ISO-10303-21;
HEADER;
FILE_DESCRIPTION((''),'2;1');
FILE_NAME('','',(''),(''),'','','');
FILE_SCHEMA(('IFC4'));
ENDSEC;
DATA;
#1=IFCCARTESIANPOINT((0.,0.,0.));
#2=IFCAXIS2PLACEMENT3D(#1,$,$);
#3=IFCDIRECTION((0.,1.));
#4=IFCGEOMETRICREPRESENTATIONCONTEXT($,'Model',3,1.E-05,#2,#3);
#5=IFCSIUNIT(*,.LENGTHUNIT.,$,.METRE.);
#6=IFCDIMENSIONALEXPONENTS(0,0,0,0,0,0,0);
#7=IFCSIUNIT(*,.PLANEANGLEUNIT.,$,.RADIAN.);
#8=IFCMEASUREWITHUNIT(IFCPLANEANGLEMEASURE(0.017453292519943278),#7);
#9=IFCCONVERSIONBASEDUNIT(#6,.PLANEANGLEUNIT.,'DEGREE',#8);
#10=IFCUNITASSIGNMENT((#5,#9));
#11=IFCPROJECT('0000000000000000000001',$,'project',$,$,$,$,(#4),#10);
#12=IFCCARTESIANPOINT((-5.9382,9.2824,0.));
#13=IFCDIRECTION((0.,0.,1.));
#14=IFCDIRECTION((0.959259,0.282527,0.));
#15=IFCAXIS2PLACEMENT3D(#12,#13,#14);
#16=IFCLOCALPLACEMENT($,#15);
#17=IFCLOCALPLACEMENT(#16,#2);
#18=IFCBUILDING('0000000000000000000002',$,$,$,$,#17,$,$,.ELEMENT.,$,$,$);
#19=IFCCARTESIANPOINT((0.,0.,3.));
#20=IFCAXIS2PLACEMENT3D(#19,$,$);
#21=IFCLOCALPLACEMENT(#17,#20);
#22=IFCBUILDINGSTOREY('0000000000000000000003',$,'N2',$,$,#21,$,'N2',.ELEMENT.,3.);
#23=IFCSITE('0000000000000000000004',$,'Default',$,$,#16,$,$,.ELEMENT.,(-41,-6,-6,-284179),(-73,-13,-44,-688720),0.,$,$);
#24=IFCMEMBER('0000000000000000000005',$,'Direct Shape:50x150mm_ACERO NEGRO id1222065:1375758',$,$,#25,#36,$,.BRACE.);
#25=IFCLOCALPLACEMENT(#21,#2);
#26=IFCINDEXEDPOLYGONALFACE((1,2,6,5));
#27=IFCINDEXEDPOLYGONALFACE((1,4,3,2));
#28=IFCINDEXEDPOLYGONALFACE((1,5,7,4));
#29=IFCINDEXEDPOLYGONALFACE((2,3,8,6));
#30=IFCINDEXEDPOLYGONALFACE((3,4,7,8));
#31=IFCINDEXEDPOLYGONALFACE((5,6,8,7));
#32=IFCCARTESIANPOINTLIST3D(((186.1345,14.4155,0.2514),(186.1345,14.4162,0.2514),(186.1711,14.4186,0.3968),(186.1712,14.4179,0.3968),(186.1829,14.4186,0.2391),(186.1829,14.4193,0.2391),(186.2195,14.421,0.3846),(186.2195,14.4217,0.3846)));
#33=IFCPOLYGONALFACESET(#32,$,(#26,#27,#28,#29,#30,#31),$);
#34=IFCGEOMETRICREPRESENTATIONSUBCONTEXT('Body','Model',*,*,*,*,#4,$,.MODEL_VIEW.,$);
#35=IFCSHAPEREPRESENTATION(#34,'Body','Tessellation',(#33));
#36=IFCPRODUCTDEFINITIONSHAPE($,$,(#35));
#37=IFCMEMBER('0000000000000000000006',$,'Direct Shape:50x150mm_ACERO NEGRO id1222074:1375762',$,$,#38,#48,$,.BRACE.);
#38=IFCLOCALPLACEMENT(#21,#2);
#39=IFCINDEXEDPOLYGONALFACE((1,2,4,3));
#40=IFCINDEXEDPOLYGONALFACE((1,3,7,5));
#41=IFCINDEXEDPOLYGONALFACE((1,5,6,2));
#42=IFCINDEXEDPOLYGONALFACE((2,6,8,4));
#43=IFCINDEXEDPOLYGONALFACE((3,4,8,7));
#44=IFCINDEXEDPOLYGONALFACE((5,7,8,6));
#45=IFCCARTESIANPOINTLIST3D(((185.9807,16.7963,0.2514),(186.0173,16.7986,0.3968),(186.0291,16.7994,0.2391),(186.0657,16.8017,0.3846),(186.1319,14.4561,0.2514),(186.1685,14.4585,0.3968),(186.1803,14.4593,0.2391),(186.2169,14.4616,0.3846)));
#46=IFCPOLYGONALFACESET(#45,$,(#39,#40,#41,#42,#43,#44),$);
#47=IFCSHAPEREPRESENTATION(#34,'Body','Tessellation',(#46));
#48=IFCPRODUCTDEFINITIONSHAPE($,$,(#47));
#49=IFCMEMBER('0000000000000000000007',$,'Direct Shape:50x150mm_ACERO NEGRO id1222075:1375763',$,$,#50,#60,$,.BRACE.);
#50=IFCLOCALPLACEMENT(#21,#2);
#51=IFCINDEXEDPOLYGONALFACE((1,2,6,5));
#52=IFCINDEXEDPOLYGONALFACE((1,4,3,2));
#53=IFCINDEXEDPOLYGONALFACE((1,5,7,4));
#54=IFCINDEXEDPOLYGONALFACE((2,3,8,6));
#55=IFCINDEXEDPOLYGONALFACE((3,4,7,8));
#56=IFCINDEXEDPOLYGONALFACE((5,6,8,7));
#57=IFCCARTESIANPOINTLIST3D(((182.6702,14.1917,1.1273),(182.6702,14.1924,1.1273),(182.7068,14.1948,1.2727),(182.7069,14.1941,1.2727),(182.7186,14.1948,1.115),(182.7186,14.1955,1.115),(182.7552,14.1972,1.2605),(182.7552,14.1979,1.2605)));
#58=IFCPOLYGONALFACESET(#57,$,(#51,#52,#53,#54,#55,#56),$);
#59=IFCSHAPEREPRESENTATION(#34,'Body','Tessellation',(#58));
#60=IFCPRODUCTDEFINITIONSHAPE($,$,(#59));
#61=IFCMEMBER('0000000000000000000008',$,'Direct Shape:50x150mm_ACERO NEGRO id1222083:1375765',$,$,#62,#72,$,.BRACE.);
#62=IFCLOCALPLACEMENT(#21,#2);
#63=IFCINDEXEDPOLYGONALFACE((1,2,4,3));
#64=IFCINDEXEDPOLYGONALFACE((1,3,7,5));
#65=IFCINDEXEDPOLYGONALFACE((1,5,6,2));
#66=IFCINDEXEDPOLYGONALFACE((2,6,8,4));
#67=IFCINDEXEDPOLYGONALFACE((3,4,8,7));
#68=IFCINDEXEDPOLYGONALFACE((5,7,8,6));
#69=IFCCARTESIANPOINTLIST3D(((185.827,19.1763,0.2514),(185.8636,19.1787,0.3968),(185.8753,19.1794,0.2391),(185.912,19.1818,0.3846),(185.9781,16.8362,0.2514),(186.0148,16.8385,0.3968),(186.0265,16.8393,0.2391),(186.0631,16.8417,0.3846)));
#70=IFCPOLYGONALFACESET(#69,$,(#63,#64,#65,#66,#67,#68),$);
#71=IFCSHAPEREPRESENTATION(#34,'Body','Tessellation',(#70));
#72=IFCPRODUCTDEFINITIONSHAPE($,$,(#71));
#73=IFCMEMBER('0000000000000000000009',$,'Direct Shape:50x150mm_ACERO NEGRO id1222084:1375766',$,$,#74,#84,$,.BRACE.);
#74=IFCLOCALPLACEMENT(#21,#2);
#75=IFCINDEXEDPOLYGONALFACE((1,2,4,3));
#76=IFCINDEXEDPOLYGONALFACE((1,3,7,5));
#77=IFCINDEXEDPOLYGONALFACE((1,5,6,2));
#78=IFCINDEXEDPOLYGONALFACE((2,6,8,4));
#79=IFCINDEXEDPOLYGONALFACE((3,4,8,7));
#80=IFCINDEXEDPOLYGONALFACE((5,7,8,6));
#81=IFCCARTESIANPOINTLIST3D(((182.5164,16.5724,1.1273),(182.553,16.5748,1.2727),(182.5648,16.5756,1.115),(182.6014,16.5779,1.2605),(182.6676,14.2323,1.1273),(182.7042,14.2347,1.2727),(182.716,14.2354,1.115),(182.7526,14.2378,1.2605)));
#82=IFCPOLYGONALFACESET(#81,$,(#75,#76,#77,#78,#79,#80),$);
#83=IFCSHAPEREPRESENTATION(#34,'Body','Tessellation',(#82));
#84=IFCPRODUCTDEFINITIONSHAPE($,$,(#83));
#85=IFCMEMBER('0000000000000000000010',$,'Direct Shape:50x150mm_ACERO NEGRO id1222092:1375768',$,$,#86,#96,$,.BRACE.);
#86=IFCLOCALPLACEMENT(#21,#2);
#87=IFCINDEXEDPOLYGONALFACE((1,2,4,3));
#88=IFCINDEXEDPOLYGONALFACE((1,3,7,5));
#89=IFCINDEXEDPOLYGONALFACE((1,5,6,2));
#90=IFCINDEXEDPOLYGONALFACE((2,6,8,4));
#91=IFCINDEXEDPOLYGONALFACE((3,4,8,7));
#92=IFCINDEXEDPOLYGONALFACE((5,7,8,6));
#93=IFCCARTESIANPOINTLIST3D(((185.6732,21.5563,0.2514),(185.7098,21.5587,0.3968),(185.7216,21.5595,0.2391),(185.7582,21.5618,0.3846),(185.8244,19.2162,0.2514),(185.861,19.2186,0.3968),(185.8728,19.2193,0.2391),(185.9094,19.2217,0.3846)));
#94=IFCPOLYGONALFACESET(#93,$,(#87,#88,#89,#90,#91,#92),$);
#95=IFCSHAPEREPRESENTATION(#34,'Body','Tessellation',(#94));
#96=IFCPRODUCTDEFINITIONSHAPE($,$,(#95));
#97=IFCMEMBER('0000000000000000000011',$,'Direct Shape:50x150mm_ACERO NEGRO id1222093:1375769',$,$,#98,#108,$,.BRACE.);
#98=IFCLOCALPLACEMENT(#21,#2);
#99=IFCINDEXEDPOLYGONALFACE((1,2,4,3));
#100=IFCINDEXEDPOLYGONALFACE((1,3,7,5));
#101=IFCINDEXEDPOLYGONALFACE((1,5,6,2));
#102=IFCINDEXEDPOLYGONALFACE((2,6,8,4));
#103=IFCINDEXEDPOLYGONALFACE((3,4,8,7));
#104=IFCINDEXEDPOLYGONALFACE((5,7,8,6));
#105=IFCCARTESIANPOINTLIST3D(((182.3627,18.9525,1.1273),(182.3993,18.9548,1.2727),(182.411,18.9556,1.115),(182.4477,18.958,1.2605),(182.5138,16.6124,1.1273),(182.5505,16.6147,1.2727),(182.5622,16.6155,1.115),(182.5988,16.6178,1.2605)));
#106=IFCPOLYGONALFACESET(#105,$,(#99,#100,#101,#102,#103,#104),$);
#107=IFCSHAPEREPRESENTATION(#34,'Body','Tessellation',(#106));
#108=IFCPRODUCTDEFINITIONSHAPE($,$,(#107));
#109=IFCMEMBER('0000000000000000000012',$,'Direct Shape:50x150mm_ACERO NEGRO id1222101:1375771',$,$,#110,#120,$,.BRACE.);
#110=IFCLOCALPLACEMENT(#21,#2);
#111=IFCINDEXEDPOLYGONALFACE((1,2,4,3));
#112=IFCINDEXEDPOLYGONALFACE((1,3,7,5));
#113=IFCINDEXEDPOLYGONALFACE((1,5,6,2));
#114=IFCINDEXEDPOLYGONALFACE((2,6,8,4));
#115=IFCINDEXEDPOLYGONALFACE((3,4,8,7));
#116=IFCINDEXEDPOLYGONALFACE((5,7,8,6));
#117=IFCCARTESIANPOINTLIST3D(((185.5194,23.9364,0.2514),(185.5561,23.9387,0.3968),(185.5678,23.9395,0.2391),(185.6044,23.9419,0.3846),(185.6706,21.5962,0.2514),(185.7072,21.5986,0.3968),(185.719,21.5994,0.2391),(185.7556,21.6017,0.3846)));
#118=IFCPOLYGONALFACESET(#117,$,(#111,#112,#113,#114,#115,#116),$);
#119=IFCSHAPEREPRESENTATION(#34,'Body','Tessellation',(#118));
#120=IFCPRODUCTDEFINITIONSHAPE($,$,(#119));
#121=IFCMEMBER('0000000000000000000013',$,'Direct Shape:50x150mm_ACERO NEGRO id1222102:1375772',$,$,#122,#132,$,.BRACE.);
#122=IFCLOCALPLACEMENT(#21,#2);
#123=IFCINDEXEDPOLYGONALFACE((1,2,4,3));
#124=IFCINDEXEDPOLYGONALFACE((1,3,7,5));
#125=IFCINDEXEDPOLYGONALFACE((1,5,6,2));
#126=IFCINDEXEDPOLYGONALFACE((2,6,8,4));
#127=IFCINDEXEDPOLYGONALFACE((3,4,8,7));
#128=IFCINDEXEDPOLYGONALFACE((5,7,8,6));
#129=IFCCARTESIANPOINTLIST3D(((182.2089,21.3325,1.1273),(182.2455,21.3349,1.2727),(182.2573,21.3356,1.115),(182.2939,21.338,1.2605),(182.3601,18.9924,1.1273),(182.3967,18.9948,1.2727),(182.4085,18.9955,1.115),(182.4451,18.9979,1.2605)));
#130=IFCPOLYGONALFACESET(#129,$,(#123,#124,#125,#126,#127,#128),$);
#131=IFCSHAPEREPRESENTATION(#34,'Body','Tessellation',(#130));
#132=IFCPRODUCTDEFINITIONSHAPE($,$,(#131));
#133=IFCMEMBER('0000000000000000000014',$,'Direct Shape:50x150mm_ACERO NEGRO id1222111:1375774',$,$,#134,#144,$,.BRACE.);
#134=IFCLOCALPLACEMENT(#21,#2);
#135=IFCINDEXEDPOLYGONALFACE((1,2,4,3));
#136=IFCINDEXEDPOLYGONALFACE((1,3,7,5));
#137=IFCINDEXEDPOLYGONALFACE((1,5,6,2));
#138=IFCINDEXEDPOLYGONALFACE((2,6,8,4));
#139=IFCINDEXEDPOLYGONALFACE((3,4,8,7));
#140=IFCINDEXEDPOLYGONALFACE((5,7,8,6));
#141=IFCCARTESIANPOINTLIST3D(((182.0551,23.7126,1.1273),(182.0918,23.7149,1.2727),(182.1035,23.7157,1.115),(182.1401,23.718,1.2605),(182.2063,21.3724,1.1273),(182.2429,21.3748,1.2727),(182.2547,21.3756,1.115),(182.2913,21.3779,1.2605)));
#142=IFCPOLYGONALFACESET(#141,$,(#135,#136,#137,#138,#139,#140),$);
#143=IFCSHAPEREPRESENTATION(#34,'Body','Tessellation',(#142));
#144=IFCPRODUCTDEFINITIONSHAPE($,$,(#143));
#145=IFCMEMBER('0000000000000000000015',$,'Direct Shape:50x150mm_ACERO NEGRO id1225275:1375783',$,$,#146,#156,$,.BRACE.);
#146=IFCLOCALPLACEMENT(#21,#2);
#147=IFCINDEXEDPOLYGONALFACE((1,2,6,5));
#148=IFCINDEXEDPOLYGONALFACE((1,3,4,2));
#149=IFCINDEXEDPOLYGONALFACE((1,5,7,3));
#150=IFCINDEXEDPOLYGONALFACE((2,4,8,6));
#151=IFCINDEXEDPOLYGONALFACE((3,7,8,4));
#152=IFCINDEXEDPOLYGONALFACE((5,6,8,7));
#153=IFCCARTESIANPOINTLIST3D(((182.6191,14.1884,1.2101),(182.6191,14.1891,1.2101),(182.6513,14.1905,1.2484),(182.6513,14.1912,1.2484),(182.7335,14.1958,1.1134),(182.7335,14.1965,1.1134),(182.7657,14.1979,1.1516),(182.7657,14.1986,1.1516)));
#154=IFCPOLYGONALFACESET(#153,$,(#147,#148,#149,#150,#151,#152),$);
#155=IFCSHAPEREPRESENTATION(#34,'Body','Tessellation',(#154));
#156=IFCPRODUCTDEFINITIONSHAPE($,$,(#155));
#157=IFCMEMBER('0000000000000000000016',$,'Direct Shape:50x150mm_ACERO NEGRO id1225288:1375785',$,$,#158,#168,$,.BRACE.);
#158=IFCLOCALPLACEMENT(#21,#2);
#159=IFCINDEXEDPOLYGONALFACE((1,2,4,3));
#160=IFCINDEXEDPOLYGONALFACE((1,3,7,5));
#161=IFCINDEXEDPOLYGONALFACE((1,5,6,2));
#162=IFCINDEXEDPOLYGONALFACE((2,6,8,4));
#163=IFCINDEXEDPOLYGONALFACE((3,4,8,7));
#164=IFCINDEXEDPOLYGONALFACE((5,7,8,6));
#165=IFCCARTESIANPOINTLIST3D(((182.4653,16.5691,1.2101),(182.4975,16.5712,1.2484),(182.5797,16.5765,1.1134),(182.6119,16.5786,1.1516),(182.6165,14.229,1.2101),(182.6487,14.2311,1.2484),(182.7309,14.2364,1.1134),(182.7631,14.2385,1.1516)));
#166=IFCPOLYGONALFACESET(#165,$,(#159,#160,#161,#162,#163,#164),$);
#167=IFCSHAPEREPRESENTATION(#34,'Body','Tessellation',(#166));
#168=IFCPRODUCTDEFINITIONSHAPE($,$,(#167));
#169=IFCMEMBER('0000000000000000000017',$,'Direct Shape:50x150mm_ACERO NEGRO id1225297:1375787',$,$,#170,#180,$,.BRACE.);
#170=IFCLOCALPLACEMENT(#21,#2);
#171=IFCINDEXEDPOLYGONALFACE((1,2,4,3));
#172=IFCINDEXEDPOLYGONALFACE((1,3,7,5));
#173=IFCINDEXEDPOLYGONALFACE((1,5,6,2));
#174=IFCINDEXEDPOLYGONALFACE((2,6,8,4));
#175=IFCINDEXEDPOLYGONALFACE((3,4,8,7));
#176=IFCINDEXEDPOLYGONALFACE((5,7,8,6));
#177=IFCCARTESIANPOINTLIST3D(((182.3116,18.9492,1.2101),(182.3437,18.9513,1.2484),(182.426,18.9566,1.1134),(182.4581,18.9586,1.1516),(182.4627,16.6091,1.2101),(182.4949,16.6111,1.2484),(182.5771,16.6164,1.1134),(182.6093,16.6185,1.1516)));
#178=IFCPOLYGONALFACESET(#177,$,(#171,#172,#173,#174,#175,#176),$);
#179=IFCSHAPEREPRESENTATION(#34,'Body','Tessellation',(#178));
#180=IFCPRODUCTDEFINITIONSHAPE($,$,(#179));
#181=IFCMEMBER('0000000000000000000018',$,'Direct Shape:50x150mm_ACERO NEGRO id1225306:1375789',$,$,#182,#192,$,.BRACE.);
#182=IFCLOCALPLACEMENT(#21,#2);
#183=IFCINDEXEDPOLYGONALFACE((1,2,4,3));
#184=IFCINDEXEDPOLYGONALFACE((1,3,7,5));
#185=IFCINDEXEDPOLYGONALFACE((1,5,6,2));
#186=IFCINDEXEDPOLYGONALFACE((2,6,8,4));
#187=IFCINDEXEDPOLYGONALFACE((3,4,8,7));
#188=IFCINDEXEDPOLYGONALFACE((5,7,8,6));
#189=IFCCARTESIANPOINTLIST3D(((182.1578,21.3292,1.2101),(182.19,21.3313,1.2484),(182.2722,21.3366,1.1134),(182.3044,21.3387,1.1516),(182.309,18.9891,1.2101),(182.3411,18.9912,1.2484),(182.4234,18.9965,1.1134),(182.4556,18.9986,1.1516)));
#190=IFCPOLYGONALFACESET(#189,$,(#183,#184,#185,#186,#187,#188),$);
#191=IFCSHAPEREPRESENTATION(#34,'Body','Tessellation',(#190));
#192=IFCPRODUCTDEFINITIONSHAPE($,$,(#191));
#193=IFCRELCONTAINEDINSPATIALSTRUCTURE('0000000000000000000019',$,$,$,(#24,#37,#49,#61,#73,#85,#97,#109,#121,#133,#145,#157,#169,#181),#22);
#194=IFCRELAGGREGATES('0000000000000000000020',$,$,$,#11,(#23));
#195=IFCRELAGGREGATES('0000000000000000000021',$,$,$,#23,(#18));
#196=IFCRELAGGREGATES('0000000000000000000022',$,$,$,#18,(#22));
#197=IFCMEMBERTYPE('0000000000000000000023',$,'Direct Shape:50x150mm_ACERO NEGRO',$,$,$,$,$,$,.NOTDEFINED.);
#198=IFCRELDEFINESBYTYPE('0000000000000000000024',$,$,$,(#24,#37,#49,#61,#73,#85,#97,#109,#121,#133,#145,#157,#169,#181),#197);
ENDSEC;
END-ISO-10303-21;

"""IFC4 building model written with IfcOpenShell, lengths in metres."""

from ifc_helpers import new_model, entity, si_unit, converted_unit, direction, frame, frame_2d, origin, origin_2d_with_axis, place, context, subcontext, project, spatial, rectangle, extrude, type_object, element, save


model = new_model("IFC4")

# Units and contexts
model_context = context("Model", 3, precision=1e-05, world=origin(), true_north=direction((0.0, 1.0)))
body_context = subcontext(model_context, "Body", "Model", "MODEL_VIEW")
ifc_project = project(units=[si_unit("LENGTHUNIT", "METRE"), converted_unit("PLANEANGLEUNIT", "DEGREE", entity("IfcPlaneAngleMeasure", 0.017453292519943278), si_unit("PLANEANGLEUNIT", "RADIAN"), dimensions=[0, 0, 0, 0, 0, 0, 0])], contexts=[model_context])

# Site, building, storey
site_placement = place(None, frame((-5.9382, 9.2824, 0.0), z_axis=(0.0, 0.0, 1.0), x_axis=(0.959259, 0.282527, 0.0)))
site = spatial("IfcSite", under=ifc_project, at=site_placement, Name="Default", CompositionType="ELEMENT", RefLatitude=(-41, -6, -6, -284179), RefLongitude=(-73, -13, -44, -688720), RefElevation=0.0)
building_placement = place(site_placement, origin())
building = spatial("IfcBuilding", under=site, at=building_placement, CompositionType="ELEMENT")
storey_placement = place(building_placement, frame((0.0, 0.0, 3.0)))
storey = spatial("IfcBuildingStorey", under=building, at=storey_placement, Name="N2", LongName="N2", CompositionType="ELEMENT", Elevation=3.0)

# Members
member_type_1 = type_object("IfcMemberType", Name="Direct Shape:50x150mm_ACERO NEGRO", PredefinedType="NOTDEFINED")
member_1_placement = place(storey_placement, origin())
element("IfcMember", 1, at=member_1_placement, inside=storey, type_object=member_type_1, Name="Direct Shape:50x150mm_ACERO NEGRO id1222065:1375758", PredefinedType="BRACE", context=body_context, shape_type="SweptSolid", body=[
    extrude(rectangle(XDim=0.05, YDim=0.0007, at=frame_2d((0.0, 0.0), x_axis=(0.0, 1.0))), frame((186.1587, 14.4174, 0.2452), z_axis=(0.24414, 0.015773, 0.969612), x_axis=(-0.064471, 0.99792, 0.0)), (0.0, 0.0, 1.0), 0.15),
])
member_2_placement = place(storey_placement, origin())
element("IfcMember", 2, at=member_2_placement, inside=storey, type_object=member_type_1, Name="Direct Shape:50x150mm_ACERO NEGRO id1222074:1375762", PredefinedType="BRACE", context=body_context, shape_type="SweptSolid", body=[
    extrude(rectangle(XDim=0.15, YDim=0.05, at=frame_2d((0.0, 0.0), x_axis=(1.0, 0.0))), frame((186.1744, 14.4589, 0.318), z_axis=(-0.064471, 0.99792, 0.0), x_axis=(-0.24414, -0.015773, -0.969612)), (0.0, 0.0, 1.0), 2.345),
])
member_3_placement = place(storey_placement, origin())
element("IfcMember", 3, at=member_3_placement, inside=storey, type_object=member_type_1, Name="Direct Shape:50x150mm_ACERO NEGRO id1222075:1375763", PredefinedType="BRACE", context=body_context, shape_type="SweptSolid", body=[
    extrude(rectangle(XDim=0.05, YDim=0.0007, at=frame_2d((0.0, 0.0), x_axis=(0.0, 1.0))), frame((182.6944, 14.1936, 1.1212), z_axis=(0.24414, 0.015773, 0.969612), x_axis=(-0.064471, 0.99792, 0.0)), (0.0, 0.0, 1.0), 0.15),
])
member_4_placement = place(storey_placement, origin())
element("IfcMember", 4, at=member_4_placement, inside=storey, type_object=member_type_1, Name="Direct Shape:50x150mm_ACERO NEGRO id1222083:1375765", PredefinedType="BRACE", context=body_context, shape_type="SweptSolid", body=[
    extrude(rectangle(XDim=0.15, YDim=0.05, at=frame_2d((0.0, 0.0), x_axis=(1.0, 0.0))), frame((186.0206, 16.8389, 0.318), z_axis=(-0.064471, 0.99792, 0.0), x_axis=(-0.24414, -0.015773, -0.969612)), (0.0, 0.0, 1.0), 2.345),
])
member_5_placement = place(storey_placement, origin())
element("IfcMember", 5, at=member_5_placement, inside=storey, type_object=member_type_1, Name="Direct Shape:50x150mm_ACERO NEGRO id1222084:1375766", PredefinedType="BRACE", context=body_context, shape_type="SweptSolid", body=[
    extrude(rectangle(XDim=0.15, YDim=0.05, at=frame_2d((0.0, 0.0), x_axis=(0.0, 1.0))), frame((182.7101, 14.2351, 1.1939), z_axis=(-0.064471, 0.99792, 0.0), x_axis=(0.967595, 0.062512, -0.244649)), (0.0, 0.0, 1.0), 2.345),
])
member_6_placement = place(storey_placement, origin())
element("IfcMember", 6, at=member_6_placement, inside=storey, type_object=member_type_1, Name="Direct Shape:50x150mm_ACERO NEGRO id1222092:1375768", PredefinedType="BRACE", context=body_context, shape_type="SweptSolid", body=[
    extrude(rectangle(XDim=0.15, YDim=0.05, at=origin_2d_with_axis()), frame((185.8669, 19.219, 0.318), z_axis=(-0.064471, 0.99792, 0.0), x_axis=(-0.24414, -0.015773, -0.969612)), (0.0, 0.0, 1.0), 2.345),
])
member_7_placement = place(storey_placement, origin())
element("IfcMember", 7, at=member_7_placement, inside=storey, type_object=member_type_1, Name="Direct Shape:50x150mm_ACERO NEGRO id1222093:1375769", PredefinedType="BRACE", context=body_context, shape_type="SweptSolid", body=[
    extrude(rectangle(XDim=0.15, YDim=0.05, at=frame_2d((0.0, 0.0), x_axis=(0.0, 1.0))), frame((182.5563, 16.6151, 1.1939), z_axis=(-0.064471, 0.99792, 0.0), x_axis=(0.967595, 0.062512, -0.244649)), (0.0, 0.0, 1.0), 2.345),
])
member_8_placement = place(storey_placement, origin())
element("IfcMember", 8, at=member_8_placement, inside=storey, type_object=member_type_1, Name="Direct Shape:50x150mm_ACERO NEGRO id1222101:1375771", PredefinedType="BRACE", context=body_context, shape_type="SweptSolid", body=[
    extrude(rectangle(XDim=0.15, YDim=0.05, at=frame_2d((0.0, 0.0), x_axis=(1.0, 0.0))), frame((185.7131, 21.599, 0.318), z_axis=(-0.064471, 0.99792, 0.0), x_axis=(-0.24414, -0.015773, -0.969612)), (0.0, 0.0, 1.0), 2.345),
])
member_9_placement = place(storey_placement, origin())
element("IfcMember", 9, at=member_9_placement, inside=storey, type_object=member_type_1, Name="Direct Shape:50x150mm_ACERO NEGRO id1222102:1375772", PredefinedType="BRACE", context=body_context, shape_type="SweptSolid", body=[
    extrude(rectangle(XDim=0.15, YDim=0.05, at=frame_2d((0.0, 0.0), x_axis=(0.0, 1.0))), frame((182.4026, 18.9951, 1.1939), z_axis=(-0.064471, 0.99792, 0.0), x_axis=(0.967595, 0.062512, -0.244649)), (0.0, 0.0, 1.0), 2.345),
])
member_10_placement = place(storey_placement, origin())
element("IfcMember", 10, at=member_10_placement, inside=storey, type_object=member_type_1, Name="Direct Shape:50x150mm_ACERO NEGRO id1222111:1375774", PredefinedType="BRACE", context=body_context, shape_type="SweptSolid", body=[
    extrude(rectangle(XDim=0.15, YDim=0.05, at=frame_2d((0.0, 0.0), x_axis=(0.0, 1.0))), frame((182.2488, 21.3752, 1.1939), z_axis=(-0.064471, 0.99792, 0.0), x_axis=(0.967595, 0.062512, -0.244649)), (0.0, 0.0, 1.0), 2.345),
])
member_11_placement = place(storey_placement, origin())
element("IfcMember", 11, at=member_11_placement, inside=storey, type_object=member_type_1, Name="Direct Shape:50x150mm_ACERO NEGRO id1225275:1375783", PredefinedType="BRACE", context=body_context, shape_type="SweptSolid", body=[
    extrude(rectangle(XDim=0.05, YDim=0.0007, at=frame_2d((0.0, 0.0), x_axis=(0.0, 1.0))), frame((182.6352, 14.1898, 1.2293), z_axis=(0.762714, 0.049276, -0.644857), x_axis=(-0.064471, 0.99792, 0.0)), (0.0, 0.0, 1.0), 0.15),
])
member_12_placement = place(storey_placement, origin())
element("IfcMember", 12, at=member_12_placement, inside=storey, type_object=member_type_1, Name="Direct Shape:50x150mm_ACERO NEGRO id1225288:1375785", PredefinedType="BRACE", context=body_context, shape_type="SweptSolid", body=[
    extrude(rectangle(XDim=0.05, YDim=0.15, at=frame_2d((0.0, 0.0), x_axis=(0.0, 1.0))), frame((182.6898, 14.2338, 1.1809), z_axis=(-0.064471, 0.99792, 0.0), x_axis=(0.762714, 0.049276, -0.644857)), (0.0, 0.0, 1.0), 2.345),
])
member_13_placement = place(storey_placement, origin())
element("IfcMember", 13, at=member_13_placement, inside=storey, type_object=member_type_1, Name="Direct Shape:50x150mm_ACERO NEGRO id1225297:1375787", PredefinedType="BRACE", context=body_context, shape_type="SweptSolid", body=[
    extrude(rectangle(XDim=0.05, YDim=0.15, at=frame_2d((0.0, 0.0), x_axis=(0.0, 1.0))), frame((182.536, 16.6138, 1.1809), z_axis=(-0.064471, 0.99792, 0.0), x_axis=(0.762714, 0.049276, -0.644857)), (0.0, 0.0, 1.0), 2.345),
])
member_14_placement = place(storey_placement, origin())
element("IfcMember", 14, at=member_14_placement, inside=storey, type_object=member_type_1, Name="Direct Shape:50x150mm_ACERO NEGRO id1225306:1375789", PredefinedType="BRACE", context=body_context, shape_type="SweptSolid", body=[
    extrude(rectangle(XDim=0.05, YDim=0.15, at=frame_2d((0.0, 0.0), x_axis=(0.0, 1.0))), frame((182.3823, 18.9938, 1.1809), z_axis=(-0.064471, 0.99792, 0.0), x_axis=(0.762714, 0.049276, -0.644857)), (0.0, 0.0, 1.0), 2.345),
])

save(model, "model.ifc")
